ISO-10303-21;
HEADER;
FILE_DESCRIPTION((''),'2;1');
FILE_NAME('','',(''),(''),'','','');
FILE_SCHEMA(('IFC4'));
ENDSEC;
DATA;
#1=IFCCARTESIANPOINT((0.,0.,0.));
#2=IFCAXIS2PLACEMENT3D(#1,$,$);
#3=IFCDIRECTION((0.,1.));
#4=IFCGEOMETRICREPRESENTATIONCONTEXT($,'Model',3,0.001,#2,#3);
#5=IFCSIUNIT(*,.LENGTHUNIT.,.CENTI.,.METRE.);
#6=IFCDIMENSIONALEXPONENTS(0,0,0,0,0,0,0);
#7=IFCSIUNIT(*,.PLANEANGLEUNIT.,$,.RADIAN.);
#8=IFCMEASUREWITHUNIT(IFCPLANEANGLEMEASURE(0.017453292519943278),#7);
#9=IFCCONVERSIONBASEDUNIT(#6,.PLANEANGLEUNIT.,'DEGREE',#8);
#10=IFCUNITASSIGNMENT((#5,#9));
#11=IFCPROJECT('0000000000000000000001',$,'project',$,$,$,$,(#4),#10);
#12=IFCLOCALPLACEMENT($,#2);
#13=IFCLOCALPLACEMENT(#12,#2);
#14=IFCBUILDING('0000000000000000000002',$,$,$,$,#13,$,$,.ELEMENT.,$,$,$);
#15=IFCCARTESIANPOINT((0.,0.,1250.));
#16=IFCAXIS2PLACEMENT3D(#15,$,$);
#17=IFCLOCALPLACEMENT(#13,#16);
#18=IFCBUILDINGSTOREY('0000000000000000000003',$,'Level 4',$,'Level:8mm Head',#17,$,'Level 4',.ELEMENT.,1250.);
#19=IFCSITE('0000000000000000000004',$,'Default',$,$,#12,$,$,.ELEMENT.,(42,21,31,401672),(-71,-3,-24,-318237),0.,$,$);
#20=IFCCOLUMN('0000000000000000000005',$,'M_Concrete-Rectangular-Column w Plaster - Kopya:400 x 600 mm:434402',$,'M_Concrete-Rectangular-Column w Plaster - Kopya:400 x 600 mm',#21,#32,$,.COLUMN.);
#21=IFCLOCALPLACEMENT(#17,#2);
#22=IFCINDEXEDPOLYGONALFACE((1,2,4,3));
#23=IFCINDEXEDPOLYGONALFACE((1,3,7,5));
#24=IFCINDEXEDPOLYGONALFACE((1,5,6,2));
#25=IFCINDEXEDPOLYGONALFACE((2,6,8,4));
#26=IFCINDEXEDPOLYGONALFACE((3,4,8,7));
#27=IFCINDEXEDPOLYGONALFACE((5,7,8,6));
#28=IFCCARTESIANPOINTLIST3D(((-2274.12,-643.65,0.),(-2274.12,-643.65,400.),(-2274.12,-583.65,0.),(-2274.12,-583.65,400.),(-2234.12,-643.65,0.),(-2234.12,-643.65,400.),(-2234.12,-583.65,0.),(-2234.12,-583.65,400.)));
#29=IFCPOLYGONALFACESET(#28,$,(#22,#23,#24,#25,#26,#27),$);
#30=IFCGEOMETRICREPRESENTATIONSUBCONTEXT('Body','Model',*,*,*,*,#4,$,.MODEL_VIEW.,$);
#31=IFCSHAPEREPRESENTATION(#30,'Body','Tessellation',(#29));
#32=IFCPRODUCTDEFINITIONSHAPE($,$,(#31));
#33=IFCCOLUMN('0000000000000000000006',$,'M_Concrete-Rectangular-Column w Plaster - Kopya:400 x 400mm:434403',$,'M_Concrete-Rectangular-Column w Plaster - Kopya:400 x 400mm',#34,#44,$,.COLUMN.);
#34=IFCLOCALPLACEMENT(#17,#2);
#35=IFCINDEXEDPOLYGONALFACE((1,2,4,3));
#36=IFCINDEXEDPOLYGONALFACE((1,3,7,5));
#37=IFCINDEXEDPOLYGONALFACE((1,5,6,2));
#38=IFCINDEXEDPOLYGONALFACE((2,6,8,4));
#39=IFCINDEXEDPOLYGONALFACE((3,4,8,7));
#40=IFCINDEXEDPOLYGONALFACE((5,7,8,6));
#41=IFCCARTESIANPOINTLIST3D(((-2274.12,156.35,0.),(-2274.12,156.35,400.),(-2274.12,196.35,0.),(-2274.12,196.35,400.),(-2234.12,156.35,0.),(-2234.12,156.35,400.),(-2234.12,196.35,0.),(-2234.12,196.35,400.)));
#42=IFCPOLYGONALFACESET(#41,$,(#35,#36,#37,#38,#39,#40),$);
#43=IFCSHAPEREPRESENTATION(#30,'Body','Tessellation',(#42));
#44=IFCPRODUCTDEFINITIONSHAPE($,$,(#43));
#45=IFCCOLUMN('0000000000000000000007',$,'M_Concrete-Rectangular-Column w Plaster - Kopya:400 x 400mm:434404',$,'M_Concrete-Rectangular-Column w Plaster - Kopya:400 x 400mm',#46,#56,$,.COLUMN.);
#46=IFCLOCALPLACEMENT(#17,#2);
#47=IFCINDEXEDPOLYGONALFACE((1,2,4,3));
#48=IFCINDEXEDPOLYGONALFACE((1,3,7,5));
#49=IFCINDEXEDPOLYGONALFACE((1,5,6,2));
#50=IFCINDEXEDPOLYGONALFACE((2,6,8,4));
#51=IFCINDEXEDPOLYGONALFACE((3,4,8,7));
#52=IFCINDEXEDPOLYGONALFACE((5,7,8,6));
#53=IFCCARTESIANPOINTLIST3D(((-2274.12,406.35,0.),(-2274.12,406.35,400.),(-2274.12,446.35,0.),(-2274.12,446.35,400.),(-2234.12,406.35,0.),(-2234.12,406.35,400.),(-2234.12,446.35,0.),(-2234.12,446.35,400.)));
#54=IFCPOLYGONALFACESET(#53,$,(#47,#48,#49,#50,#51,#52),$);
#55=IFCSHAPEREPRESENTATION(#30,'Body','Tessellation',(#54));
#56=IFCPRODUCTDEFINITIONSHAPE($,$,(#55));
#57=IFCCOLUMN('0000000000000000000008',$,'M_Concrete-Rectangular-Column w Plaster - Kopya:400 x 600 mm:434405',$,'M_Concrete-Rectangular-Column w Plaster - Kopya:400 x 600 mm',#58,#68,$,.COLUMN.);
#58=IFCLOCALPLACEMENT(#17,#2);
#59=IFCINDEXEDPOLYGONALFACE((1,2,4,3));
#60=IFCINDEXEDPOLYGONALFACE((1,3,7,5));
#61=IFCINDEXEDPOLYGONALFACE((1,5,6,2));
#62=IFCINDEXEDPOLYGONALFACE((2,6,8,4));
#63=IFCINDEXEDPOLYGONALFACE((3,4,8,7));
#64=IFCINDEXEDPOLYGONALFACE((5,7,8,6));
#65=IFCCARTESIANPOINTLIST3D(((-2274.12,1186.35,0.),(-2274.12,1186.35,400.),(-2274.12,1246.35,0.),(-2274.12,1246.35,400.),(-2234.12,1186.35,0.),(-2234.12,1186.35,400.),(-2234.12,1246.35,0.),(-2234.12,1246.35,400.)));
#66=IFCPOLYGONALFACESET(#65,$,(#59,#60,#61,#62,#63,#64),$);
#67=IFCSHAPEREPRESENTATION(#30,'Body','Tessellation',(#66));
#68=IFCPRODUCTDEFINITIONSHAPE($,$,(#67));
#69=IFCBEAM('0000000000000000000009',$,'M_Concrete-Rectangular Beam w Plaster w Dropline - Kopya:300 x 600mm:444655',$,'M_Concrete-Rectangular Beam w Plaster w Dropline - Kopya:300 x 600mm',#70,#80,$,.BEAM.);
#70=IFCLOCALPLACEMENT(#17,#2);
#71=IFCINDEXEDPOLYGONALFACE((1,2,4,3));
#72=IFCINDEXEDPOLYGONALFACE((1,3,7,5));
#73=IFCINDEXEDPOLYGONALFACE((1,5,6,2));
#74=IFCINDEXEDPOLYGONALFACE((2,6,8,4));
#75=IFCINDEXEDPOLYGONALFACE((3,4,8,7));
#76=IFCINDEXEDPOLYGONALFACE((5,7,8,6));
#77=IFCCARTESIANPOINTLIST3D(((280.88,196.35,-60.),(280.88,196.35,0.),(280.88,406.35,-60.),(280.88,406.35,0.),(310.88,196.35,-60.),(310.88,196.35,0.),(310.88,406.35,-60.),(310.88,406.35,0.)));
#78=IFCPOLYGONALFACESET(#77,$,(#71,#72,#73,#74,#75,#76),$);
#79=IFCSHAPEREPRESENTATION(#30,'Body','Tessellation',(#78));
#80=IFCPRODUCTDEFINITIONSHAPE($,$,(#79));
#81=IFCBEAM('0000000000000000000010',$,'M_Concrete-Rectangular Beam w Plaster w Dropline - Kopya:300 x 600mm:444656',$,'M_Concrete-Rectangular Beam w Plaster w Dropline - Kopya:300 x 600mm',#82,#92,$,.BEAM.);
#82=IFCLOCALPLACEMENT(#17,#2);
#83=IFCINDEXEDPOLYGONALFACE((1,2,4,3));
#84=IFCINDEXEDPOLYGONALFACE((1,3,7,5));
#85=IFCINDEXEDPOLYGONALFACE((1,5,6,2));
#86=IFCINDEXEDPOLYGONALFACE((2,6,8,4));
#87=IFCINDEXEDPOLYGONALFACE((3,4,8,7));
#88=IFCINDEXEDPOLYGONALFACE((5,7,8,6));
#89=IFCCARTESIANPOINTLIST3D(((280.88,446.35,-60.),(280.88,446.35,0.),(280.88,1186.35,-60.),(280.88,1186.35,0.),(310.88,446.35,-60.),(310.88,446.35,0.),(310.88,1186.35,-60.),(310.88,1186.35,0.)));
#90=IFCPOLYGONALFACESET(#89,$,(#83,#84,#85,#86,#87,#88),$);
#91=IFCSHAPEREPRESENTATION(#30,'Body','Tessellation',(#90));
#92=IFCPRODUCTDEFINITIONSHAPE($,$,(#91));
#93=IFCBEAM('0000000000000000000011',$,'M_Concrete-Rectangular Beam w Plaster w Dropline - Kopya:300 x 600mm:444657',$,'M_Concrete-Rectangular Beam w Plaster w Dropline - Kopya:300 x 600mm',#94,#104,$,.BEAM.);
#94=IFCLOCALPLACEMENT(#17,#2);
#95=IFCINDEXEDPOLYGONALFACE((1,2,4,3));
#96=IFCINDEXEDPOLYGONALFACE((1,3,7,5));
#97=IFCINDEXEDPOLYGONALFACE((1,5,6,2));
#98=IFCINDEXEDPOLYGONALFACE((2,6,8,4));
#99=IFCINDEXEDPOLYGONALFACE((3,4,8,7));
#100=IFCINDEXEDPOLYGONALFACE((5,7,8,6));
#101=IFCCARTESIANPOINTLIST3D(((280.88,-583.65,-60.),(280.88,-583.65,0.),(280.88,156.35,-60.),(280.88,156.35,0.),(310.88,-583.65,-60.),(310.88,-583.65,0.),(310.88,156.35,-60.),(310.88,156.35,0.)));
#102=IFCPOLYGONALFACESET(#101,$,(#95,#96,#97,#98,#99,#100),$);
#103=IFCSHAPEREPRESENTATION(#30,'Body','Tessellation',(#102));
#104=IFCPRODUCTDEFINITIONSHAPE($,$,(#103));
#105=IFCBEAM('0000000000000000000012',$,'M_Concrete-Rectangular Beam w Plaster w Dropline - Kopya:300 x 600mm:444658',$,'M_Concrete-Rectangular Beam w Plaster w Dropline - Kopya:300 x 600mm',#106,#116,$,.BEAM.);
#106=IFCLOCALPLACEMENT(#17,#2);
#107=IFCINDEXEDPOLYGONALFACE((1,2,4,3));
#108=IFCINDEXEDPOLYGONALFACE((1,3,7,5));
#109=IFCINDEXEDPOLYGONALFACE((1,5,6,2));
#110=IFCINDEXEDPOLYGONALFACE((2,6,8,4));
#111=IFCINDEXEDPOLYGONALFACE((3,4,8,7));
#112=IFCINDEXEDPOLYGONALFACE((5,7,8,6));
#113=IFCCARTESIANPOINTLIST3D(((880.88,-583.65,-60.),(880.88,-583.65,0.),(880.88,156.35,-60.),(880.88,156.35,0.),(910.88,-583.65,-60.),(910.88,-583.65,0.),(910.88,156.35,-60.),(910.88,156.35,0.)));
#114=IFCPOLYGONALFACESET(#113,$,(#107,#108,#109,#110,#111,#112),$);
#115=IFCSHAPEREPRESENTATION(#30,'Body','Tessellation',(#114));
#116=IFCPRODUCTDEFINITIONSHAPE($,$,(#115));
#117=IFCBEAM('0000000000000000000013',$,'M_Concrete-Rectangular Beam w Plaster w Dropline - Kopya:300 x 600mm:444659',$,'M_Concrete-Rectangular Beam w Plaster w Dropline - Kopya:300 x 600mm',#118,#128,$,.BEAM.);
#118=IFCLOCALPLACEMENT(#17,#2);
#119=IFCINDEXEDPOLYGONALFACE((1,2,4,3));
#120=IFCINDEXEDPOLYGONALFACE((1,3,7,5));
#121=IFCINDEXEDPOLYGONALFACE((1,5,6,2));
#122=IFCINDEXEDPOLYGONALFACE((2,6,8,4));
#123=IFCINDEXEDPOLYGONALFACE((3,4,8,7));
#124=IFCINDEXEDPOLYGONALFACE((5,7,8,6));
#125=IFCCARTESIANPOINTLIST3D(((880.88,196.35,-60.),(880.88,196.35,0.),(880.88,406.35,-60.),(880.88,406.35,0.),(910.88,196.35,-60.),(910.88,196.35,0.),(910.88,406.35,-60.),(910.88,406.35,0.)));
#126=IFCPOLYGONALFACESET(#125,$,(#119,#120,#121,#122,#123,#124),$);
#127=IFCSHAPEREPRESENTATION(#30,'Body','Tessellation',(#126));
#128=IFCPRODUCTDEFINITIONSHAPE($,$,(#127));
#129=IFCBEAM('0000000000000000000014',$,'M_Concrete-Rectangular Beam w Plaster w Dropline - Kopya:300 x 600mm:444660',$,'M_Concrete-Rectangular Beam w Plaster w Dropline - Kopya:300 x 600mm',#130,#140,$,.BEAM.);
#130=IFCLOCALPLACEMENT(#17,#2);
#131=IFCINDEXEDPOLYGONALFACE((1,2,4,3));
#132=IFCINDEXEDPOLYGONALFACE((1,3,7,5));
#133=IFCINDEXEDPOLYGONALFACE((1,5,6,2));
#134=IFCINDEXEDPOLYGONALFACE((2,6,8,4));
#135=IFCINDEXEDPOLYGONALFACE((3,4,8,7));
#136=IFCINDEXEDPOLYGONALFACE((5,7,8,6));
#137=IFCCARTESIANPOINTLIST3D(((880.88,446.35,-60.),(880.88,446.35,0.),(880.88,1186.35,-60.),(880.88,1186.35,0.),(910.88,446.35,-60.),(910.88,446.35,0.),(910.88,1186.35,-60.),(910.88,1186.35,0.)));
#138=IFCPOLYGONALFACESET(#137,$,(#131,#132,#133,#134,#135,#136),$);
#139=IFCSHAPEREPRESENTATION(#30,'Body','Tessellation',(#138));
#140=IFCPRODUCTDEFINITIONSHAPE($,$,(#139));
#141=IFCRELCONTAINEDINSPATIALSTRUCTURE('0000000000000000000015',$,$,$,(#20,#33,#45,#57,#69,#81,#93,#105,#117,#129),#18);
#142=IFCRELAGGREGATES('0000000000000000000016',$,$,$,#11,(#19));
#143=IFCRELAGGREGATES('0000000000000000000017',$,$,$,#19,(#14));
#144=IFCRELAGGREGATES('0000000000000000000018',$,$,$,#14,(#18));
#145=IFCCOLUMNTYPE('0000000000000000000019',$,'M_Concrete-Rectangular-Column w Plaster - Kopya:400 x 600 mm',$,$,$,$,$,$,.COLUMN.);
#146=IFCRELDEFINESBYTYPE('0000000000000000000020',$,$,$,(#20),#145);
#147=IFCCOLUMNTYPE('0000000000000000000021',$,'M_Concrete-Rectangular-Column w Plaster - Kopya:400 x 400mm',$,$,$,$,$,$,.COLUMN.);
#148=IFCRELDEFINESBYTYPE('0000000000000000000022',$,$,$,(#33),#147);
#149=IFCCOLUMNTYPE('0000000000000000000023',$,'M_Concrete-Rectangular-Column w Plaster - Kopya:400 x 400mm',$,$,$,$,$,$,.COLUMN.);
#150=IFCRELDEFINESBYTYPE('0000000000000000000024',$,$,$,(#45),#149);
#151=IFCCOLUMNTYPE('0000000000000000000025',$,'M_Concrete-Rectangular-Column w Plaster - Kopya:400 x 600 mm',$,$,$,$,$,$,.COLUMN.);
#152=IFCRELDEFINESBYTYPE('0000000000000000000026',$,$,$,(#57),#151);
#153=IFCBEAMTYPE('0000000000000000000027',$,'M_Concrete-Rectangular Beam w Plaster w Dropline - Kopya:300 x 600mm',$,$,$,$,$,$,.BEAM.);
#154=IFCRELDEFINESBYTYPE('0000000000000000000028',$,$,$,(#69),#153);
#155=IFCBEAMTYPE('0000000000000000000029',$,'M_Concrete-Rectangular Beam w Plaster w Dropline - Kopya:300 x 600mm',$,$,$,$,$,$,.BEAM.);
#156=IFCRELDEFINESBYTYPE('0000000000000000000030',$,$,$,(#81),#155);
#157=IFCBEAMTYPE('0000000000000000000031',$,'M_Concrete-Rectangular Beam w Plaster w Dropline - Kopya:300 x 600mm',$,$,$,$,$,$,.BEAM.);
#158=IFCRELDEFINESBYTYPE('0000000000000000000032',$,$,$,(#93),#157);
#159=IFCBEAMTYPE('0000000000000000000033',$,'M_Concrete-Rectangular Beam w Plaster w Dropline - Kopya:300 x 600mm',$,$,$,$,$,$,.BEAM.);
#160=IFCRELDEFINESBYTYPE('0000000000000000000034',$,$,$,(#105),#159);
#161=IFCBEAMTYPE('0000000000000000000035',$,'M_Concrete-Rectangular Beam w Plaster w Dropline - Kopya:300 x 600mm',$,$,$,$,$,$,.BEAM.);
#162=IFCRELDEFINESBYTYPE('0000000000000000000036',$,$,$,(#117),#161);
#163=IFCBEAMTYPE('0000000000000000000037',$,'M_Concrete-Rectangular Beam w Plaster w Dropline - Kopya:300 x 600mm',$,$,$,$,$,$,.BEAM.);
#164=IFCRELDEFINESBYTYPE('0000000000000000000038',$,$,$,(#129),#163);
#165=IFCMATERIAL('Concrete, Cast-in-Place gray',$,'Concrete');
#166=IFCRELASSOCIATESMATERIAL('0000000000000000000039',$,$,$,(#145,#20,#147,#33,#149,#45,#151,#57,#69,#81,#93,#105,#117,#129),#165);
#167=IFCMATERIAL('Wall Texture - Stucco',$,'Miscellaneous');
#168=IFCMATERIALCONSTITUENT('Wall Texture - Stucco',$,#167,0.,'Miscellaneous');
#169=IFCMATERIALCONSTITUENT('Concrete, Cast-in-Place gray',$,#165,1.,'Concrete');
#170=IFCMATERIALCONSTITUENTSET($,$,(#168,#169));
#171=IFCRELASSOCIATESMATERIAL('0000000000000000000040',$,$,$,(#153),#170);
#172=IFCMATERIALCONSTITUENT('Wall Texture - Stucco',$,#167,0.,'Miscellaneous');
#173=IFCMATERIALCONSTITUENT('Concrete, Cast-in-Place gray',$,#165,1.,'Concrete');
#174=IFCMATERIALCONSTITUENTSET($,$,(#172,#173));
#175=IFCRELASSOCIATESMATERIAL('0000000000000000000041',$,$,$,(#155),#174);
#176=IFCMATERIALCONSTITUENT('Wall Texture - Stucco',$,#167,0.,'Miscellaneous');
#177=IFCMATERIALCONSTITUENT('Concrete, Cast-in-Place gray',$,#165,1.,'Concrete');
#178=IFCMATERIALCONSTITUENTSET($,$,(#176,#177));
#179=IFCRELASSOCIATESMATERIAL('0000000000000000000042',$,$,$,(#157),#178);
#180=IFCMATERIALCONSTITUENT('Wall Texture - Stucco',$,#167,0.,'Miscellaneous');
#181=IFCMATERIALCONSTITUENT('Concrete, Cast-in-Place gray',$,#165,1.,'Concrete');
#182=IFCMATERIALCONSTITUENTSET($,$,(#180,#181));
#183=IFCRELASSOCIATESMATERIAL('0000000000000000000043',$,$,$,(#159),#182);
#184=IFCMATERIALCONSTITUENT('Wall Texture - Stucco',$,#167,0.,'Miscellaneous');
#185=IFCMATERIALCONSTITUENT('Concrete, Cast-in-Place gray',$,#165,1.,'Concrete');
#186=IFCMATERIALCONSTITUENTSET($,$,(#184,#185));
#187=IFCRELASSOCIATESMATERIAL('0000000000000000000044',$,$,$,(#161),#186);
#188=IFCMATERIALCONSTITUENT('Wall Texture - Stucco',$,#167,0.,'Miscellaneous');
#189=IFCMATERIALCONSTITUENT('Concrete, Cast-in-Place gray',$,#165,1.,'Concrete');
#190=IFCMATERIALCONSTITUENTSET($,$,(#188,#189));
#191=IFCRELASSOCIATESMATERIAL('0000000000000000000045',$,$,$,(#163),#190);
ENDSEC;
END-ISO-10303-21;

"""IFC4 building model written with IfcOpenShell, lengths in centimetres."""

from ifc_helpers import new_model, entity, si_unit, converted_unit, direction, frame, origin, place, context, subcontext, project, spatial, indexed_curve, outline, extrude, source, transform, mapped, material, constituent, constituent_set, type_object, type_shapes, element, save


model = new_model("IFC4")

# Units and contexts
model_context = context("Model", 3, precision=0.001, world=origin(), true_north=direction((0.0, 1.0)))
body_context = subcontext(model_context, "Body", "Model", "MODEL_VIEW")
ifc_project = project(units=[si_unit("LENGTHUNIT", "METRE", prefix="CENTI"), converted_unit("PLANEANGLEUNIT", "DEGREE", entity("IfcPlaneAngleMeasure", 0.017453292519943278), si_unit("PLANEANGLEUNIT", "RADIAN"), dimensions=[0, 0, 0, 0, 0, 0, 0])], contexts=[model_context])

# Site, building, storey
site_placement = place(None, origin())
site = spatial("IfcSite", under=ifc_project, at=site_placement, Name="Default", CompositionType="ELEMENT", RefLatitude=(42, 21, 31, 401672), RefLongitude=(-71, -3, -24, -318237), RefElevation=0.0)
building_placement = place(site_placement, origin())
building = spatial("IfcBuilding", under=site, at=building_placement, CompositionType="ELEMENT")
storey_placement = place(building_placement, frame((0.0, 0.0, 1250.0)))
storey = spatial("IfcBuildingStorey", under=building, at=storey_placement, Name="Level 4", ObjectType="Level:8mm Head", LongName="Level 4", CompositionType="ELEMENT", Elevation=1250.0)

# Columns
ifc_material_1 = material(Name="Concrete, Cast-in-Place gray", Category="Concrete")
column_type_1 = type_object("IfcColumnType", Name="M_Concrete-Rectangular-Column w Plaster - Kopya:400 x 600 mm", PredefinedType="COLUMN", material=ifc_material_1)
shared_shape_1 = source(origin(), body_context, "Body", "SweptSolid", [
    extrude(outline(indexed_curve([(-20.0, -30.0), (20.0, -30.0), (20.0, 30.0), (-20.0, 30.0), (-20.0, -30.0)], self_intersect=False)), frame((-2254.12, -613.65, 1250.0)), (0.0, 0.0, 1.0), 400.0),
])
type_shapes(column_type_1, [shared_shape_1])
column_1_placement = place(storey_placement, frame((0.0, 0.0, -1250.0)))
element("IfcColumn", 1, at=column_1_placement, inside=storey, type_object=column_type_1, material=ifc_material_1, Name="M_Concrete-Rectangular-Column w Plaster - Kopya:400 x 600 mm:434402", ObjectType="M_Concrete-Rectangular-Column w Plaster - Kopya:400 x 600 mm", PredefinedType="COLUMN", context=body_context, shape_type="MappedRepresentation", body=[
    mapped(shared_shape_1, transform((0.0, 0.0, 0.0), scale=1.0)),
])
column_type_2 = type_object("IfcColumnType", Name="M_Concrete-Rectangular-Column w Plaster - Kopya:400 x 400mm", PredefinedType="COLUMN", material=ifc_material_1)
shared_shape_2 = source(origin(), body_context, "Body", "SweptSolid", [
    extrude(outline(indexed_curve([(-20.0, -20.0), (20.0, -20.0), (20.0, 20.0), (-20.0, 20.0), (-20.0, -20.0)], self_intersect=False)), frame((-2254.12, 176.35, 1250.0)), (0.0, 0.0, 1.0), 400.0),
])
type_shapes(column_type_2, [shared_shape_2])
column_2_placement = place(storey_placement, frame((0.0, 0.0, -1250.0)))
element("IfcColumn", 2, at=column_2_placement, inside=storey, type_object=column_type_2, material=ifc_material_1, Name="M_Concrete-Rectangular-Column w Plaster - Kopya:400 x 400mm:434403", ObjectType="M_Concrete-Rectangular-Column w Plaster - Kopya:400 x 400mm", PredefinedType="COLUMN", context=body_context, shape_type="MappedRepresentation", body=[
    mapped(shared_shape_2, transform((0.0, 0.0, 0.0), scale=1.0)),
])
column_type_3 = type_object("IfcColumnType", Name="M_Concrete-Rectangular-Column w Plaster - Kopya:400 x 400mm", PredefinedType="COLUMN", material=ifc_material_1)
shared_shape_3 = source(origin(), body_context, "Body", "SweptSolid", [
    extrude(outline(indexed_curve([(-20.0, -20.0), (20.0, -20.0), (20.0, 20.0), (-20.0, 20.0), (-20.0, -20.0)], self_intersect=False)), frame((-2254.12, 426.35, 1250.0)), (0.0, 0.0, 1.0), 400.0),
])
type_shapes(column_type_3, [shared_shape_3])
column_3_placement = place(storey_placement, frame((0.0, 0.0, -1250.0)))
element("IfcColumn", 3, at=column_3_placement, inside=storey, type_object=column_type_3, material=ifc_material_1, Name="M_Concrete-Rectangular-Column w Plaster - Kopya:400 x 400mm:434404", ObjectType="M_Concrete-Rectangular-Column w Plaster - Kopya:400 x 400mm", PredefinedType="COLUMN", context=body_context, shape_type="MappedRepresentation", body=[
    mapped(shared_shape_3, transform((0.0, 0.0, 0.0), scale=1.0)),
])
column_type_4 = type_object("IfcColumnType", Name="M_Concrete-Rectangular-Column w Plaster - Kopya:400 x 600 mm", PredefinedType="COLUMN", material=ifc_material_1)
shared_shape_4 = source(origin(), body_context, "Body", "SweptSolid", [
    extrude(outline(indexed_curve([(-20.0, -30.0), (20.0, -30.0), (20.0, 30.0), (-20.0, 30.0), (-20.0, -30.0)], self_intersect=False)), frame((-2254.12, 1216.35, 1250.0), z_axis=(0.0, 0.0, 1.0), x_axis=(-1.0, 0.0, 0.0)), (0.0, 0.0, 1.0), 400.0),
])
type_shapes(column_type_4, [shared_shape_4])
column_4_placement = place(storey_placement, frame((0.0, 0.0, -1250.0)))
element("IfcColumn", 4, at=column_4_placement, inside=storey, type_object=column_type_4, material=ifc_material_1, Name="M_Concrete-Rectangular-Column w Plaster - Kopya:400 x 600 mm:434405", ObjectType="M_Concrete-Rectangular-Column w Plaster - Kopya:400 x 600 mm", PredefinedType="COLUMN", context=body_context, shape_type="MappedRepresentation", body=[
    mapped(shared_shape_4, transform((0.0, 0.0, 0.0), scale=1.0)),
])

# Beams
ifc_material_2 = material(Name="Wall Texture - Stucco", Category="Miscellaneous")
ifc_constituent_1 = constituent(ifc_material_2, Name="Wall Texture - Stucco", Category="Miscellaneous", fraction=0.0)
ifc_constituent_2 = constituent(ifc_material_1, Name="Concrete, Cast-in-Place gray", Category="Concrete", fraction=1.0)
ifc_constituent_set_1 = constituent_set(constituents=[ifc_constituent_1, ifc_constituent_2])
beam_type_1 = type_object("IfcBeamType", Name="M_Concrete-Rectangular Beam w Plaster w Dropline - Kopya:300 x 600mm", PredefinedType="BEAM", material=ifc_constituent_set_1)
shared_shape_5 = source(origin(), body_context, "Body", "SweptSolid", [
    extrude(outline(indexed_curve([(-15.0, -30.0), (15.0, -30.0), (15.0, 30.0), (-15.0, 30.0), (-15.0, -30.0)], self_intersect=False)), frame((295.88, 406.35, 1220.0), z_axis=(0.0, -1.0, 0.0), x_axis=(-1.0, 0.0, 0.0)), (0.0, 0.0, 1.0), 210.0),
])
type_shapes(beam_type_1, [shared_shape_5])
beam_1_placement = place(storey_placement, frame((0.0, 0.0, -1250.0)))
element("IfcBeam", 5, at=beam_1_placement, inside=storey, type_object=beam_type_1, material=ifc_material_1, Name="M_Concrete-Rectangular Beam w Plaster w Dropline - Kopya:300 x 600mm:444655", ObjectType="M_Concrete-Rectangular Beam w Plaster w Dropline - Kopya:300 x 600mm", PredefinedType="BEAM", context=body_context, shape_type="MappedRepresentation", body=[
    mapped(shared_shape_5, transform((0.0, 0.0, 0.0), scale=1.0)),
])
ifc_constituent_3 = constituent(ifc_material_2, Name="Wall Texture - Stucco", Category="Miscellaneous", fraction=0.0)
ifc_constituent_4 = constituent(ifc_material_1, Name="Concrete, Cast-in-Place gray", Category="Concrete", fraction=1.0)
ifc_constituent_set_2 = constituent_set(constituents=[ifc_constituent_3, ifc_constituent_4])
beam_type_2 = type_object("IfcBeamType", Name="M_Concrete-Rectangular Beam w Plaster w Dropline - Kopya:300 x 600mm", PredefinedType="BEAM", material=ifc_constituent_set_2)
shared_shape_6 = source(origin(), body_context, "Body", "SweptSolid", [
    extrude(outline(indexed_curve([(-15.0, -30.0), (15.0, -30.0), (15.0, 30.0), (-15.0, 30.0), (-15.0, -30.0)], self_intersect=False)), frame((295.88, 446.35, 1220.0), z_axis=(0.0, 1.0, 0.0), x_axis=(-1.0, 0.0, 0.0)), (0.0, 0.0, 1.0), 740.0),
])
type_shapes(beam_type_2, [shared_shape_6])
beam_2_placement = place(storey_placement, frame((0.0, 0.0, -1250.0)))
element("IfcBeam", 6, at=beam_2_placement, inside=storey, type_object=beam_type_2, material=ifc_material_1, Name="M_Concrete-Rectangular Beam w Plaster w Dropline - Kopya:300 x 600mm:444656", ObjectType="M_Concrete-Rectangular Beam w Plaster w Dropline - Kopya:300 x 600mm", PredefinedType="BEAM", context=body_context, shape_type="MappedRepresentation", body=[
    mapped(shared_shape_6, transform((0.0, 0.0, 0.0), scale=1.0)),
])
ifc_constituent_5 = constituent(ifc_material_2, Name="Wall Texture - Stucco", Category="Miscellaneous", fraction=0.0)
ifc_constituent_6 = constituent(ifc_material_1, Name="Concrete, Cast-in-Place gray", Category="Concrete", fraction=1.0)
ifc_constituent_set_3 = constituent_set(constituents=[ifc_constituent_5, ifc_constituent_6])
beam_type_3 = type_object("IfcBeamType", Name="M_Concrete-Rectangular Beam w Plaster w Dropline - Kopya:300 x 600mm", PredefinedType="BEAM", material=ifc_constituent_set_3)
shared_shape_7 = source(origin(), body_context, "Body", "SweptSolid", [
    extrude(outline(indexed_curve([(-15.0, -30.0), (15.0, -30.0), (15.0, 30.0), (-15.0, 30.0), (-15.0, -30.0)], self_intersect=False)), frame((295.88, 156.35, 1220.0), z_axis=(0.0, -1.0, 0.0), x_axis=(-1.0, 0.0, 0.0)), (0.0, 0.0, 1.0), 740.0),
])
type_shapes(beam_type_3, [shared_shape_7])
beam_3_placement = place(storey_placement, frame((0.0, 0.0, -1250.0)))
element("IfcBeam", 7, at=beam_3_placement, inside=storey, type_object=beam_type_3, material=ifc_material_1, Name="M_Concrete-Rectangular Beam w Plaster w Dropline - Kopya:300 x 600mm:444657", ObjectType="M_Concrete-Rectangular Beam w Plaster w Dropline - Kopya:300 x 600mm", PredefinedType="BEAM", context=body_context, shape_type="MappedRepresentation", body=[
    mapped(shared_shape_7, transform((0.0, 0.0, 0.0), scale=1.0)),
])
ifc_constituent_7 = constituent(ifc_material_2, Name="Wall Texture - Stucco", Category="Miscellaneous", fraction=0.0)
ifc_constituent_8 = constituent(ifc_material_1, Name="Concrete, Cast-in-Place gray", Category="Concrete", fraction=1.0)
ifc_constituent_set_4 = constituent_set(constituents=[ifc_constituent_7, ifc_constituent_8])
beam_type_4 = type_object("IfcBeamType", Name="M_Concrete-Rectangular Beam w Plaster w Dropline - Kopya:300 x 600mm", PredefinedType="BEAM", material=ifc_constituent_set_4)
shared_shape_8 = source(origin(), body_context, "Body", "SweptSolid", [
    extrude(outline(indexed_curve([(-15.0, -30.0), (15.0, -30.0), (15.0, 30.0), (-15.0, 30.0), (-15.0, -30.0)], self_intersect=False)), frame((895.88, -583.65, 1220.0), z_axis=(0.0, 1.0, 0.0), x_axis=(-1.0, 0.0, 0.0)), (0.0, 0.0, 1.0), 740.0),
])
type_shapes(beam_type_4, [shared_shape_8])
beam_4_placement = place(storey_placement, frame((0.0, 0.0, -1250.0)))
element("IfcBeam", 8, at=beam_4_placement, inside=storey, type_object=beam_type_4, material=ifc_material_1, Name="M_Concrete-Rectangular Beam w Plaster w Dropline - Kopya:300 x 600mm:444658", ObjectType="M_Concrete-Rectangular Beam w Plaster w Dropline - Kopya:300 x 600mm", PredefinedType="BEAM", context=body_context, shape_type="MappedRepresentation", body=[
    mapped(shared_shape_8, transform((0.0, 0.0, 0.0), scale=1.0)),
])
ifc_constituent_9 = constituent(ifc_material_2, Name="Wall Texture - Stucco", Category="Miscellaneous", fraction=0.0)
ifc_constituent_10 = constituent(ifc_material_1, Name="Concrete, Cast-in-Place gray", Category="Concrete", fraction=1.0)
ifc_constituent_set_5 = constituent_set(constituents=[ifc_constituent_9, ifc_constituent_10])
beam_type_5 = type_object("IfcBeamType", Name="M_Concrete-Rectangular Beam w Plaster w Dropline - Kopya:300 x 600mm", PredefinedType="BEAM", material=ifc_constituent_set_5)
shared_shape_9 = source(origin(), body_context, "Body", "SweptSolid", [
    extrude(outline(indexed_curve([(-15.0, -30.0), (15.0, -30.0), (15.0, 30.0), (-15.0, 30.0), (-15.0, -30.0)], self_intersect=False)), frame((895.88, 196.35, 1220.0), z_axis=(0.0, 1.0, 0.0), x_axis=(-1.0, 0.0, 0.0)), (0.0, 0.0, 1.0), 210.0),
])
type_shapes(beam_type_5, [shared_shape_9])
beam_5_placement = place(storey_placement, frame((0.0, 0.0, -1250.0)))
element("IfcBeam", 9, at=beam_5_placement, inside=storey, type_object=beam_type_5, material=ifc_material_1, Name="M_Concrete-Rectangular Beam w Plaster w Dropline - Kopya:300 x 600mm:444659", ObjectType="M_Concrete-Rectangular Beam w Plaster w Dropline - Kopya:300 x 600mm", PredefinedType="BEAM", context=body_context, shape_type="MappedRepresentation", body=[
    mapped(shared_shape_9, transform((0.0, 0.0, 0.0), scale=1.0)),
])
ifc_constituent_11 = constituent(ifc_material_2, Name="Wall Texture - Stucco", Category="Miscellaneous", fraction=0.0)
ifc_constituent_12 = constituent(ifc_material_1, Name="Concrete, Cast-in-Place gray", Category="Concrete", fraction=1.0)
ifc_constituent_set_6 = constituent_set(constituents=[ifc_constituent_11, ifc_constituent_12])
beam_type_6 = type_object("IfcBeamType", Name="M_Concrete-Rectangular Beam w Plaster w Dropline - Kopya:300 x 600mm", PredefinedType="BEAM", material=ifc_constituent_set_6)
shared_shape_10 = source(origin(), body_context, "Body", "SweptSolid", [
    extrude(outline(indexed_curve([(-15.0, -30.0), (15.0, -30.0), (15.0, 30.0), (-15.0, 30.0), (-15.0, -30.0)], self_intersect=False)), frame((895.88, 446.35, 1220.0), z_axis=(0.0, 1.0, 0.0), x_axis=(-1.0, 0.0, 0.0)), (0.0, 0.0, 1.0), 740.0),
])
type_shapes(beam_type_6, [shared_shape_10])
beam_6_placement = place(storey_placement, frame((0.0, 0.0, -1250.0)))
element("IfcBeam", 10, at=beam_6_placement, inside=storey, type_object=beam_type_6, material=ifc_material_1, Name="M_Concrete-Rectangular Beam w Plaster w Dropline - Kopya:300 x 600mm:444660", ObjectType="M_Concrete-Rectangular Beam w Plaster w Dropline - Kopya:300 x 600mm", PredefinedType="BEAM", context=body_context, shape_type="MappedRepresentation", body=[
    mapped(shared_shape_10, transform((0.0, 0.0, 0.0), scale=1.0)),
])

save(model, "model.ifc")
